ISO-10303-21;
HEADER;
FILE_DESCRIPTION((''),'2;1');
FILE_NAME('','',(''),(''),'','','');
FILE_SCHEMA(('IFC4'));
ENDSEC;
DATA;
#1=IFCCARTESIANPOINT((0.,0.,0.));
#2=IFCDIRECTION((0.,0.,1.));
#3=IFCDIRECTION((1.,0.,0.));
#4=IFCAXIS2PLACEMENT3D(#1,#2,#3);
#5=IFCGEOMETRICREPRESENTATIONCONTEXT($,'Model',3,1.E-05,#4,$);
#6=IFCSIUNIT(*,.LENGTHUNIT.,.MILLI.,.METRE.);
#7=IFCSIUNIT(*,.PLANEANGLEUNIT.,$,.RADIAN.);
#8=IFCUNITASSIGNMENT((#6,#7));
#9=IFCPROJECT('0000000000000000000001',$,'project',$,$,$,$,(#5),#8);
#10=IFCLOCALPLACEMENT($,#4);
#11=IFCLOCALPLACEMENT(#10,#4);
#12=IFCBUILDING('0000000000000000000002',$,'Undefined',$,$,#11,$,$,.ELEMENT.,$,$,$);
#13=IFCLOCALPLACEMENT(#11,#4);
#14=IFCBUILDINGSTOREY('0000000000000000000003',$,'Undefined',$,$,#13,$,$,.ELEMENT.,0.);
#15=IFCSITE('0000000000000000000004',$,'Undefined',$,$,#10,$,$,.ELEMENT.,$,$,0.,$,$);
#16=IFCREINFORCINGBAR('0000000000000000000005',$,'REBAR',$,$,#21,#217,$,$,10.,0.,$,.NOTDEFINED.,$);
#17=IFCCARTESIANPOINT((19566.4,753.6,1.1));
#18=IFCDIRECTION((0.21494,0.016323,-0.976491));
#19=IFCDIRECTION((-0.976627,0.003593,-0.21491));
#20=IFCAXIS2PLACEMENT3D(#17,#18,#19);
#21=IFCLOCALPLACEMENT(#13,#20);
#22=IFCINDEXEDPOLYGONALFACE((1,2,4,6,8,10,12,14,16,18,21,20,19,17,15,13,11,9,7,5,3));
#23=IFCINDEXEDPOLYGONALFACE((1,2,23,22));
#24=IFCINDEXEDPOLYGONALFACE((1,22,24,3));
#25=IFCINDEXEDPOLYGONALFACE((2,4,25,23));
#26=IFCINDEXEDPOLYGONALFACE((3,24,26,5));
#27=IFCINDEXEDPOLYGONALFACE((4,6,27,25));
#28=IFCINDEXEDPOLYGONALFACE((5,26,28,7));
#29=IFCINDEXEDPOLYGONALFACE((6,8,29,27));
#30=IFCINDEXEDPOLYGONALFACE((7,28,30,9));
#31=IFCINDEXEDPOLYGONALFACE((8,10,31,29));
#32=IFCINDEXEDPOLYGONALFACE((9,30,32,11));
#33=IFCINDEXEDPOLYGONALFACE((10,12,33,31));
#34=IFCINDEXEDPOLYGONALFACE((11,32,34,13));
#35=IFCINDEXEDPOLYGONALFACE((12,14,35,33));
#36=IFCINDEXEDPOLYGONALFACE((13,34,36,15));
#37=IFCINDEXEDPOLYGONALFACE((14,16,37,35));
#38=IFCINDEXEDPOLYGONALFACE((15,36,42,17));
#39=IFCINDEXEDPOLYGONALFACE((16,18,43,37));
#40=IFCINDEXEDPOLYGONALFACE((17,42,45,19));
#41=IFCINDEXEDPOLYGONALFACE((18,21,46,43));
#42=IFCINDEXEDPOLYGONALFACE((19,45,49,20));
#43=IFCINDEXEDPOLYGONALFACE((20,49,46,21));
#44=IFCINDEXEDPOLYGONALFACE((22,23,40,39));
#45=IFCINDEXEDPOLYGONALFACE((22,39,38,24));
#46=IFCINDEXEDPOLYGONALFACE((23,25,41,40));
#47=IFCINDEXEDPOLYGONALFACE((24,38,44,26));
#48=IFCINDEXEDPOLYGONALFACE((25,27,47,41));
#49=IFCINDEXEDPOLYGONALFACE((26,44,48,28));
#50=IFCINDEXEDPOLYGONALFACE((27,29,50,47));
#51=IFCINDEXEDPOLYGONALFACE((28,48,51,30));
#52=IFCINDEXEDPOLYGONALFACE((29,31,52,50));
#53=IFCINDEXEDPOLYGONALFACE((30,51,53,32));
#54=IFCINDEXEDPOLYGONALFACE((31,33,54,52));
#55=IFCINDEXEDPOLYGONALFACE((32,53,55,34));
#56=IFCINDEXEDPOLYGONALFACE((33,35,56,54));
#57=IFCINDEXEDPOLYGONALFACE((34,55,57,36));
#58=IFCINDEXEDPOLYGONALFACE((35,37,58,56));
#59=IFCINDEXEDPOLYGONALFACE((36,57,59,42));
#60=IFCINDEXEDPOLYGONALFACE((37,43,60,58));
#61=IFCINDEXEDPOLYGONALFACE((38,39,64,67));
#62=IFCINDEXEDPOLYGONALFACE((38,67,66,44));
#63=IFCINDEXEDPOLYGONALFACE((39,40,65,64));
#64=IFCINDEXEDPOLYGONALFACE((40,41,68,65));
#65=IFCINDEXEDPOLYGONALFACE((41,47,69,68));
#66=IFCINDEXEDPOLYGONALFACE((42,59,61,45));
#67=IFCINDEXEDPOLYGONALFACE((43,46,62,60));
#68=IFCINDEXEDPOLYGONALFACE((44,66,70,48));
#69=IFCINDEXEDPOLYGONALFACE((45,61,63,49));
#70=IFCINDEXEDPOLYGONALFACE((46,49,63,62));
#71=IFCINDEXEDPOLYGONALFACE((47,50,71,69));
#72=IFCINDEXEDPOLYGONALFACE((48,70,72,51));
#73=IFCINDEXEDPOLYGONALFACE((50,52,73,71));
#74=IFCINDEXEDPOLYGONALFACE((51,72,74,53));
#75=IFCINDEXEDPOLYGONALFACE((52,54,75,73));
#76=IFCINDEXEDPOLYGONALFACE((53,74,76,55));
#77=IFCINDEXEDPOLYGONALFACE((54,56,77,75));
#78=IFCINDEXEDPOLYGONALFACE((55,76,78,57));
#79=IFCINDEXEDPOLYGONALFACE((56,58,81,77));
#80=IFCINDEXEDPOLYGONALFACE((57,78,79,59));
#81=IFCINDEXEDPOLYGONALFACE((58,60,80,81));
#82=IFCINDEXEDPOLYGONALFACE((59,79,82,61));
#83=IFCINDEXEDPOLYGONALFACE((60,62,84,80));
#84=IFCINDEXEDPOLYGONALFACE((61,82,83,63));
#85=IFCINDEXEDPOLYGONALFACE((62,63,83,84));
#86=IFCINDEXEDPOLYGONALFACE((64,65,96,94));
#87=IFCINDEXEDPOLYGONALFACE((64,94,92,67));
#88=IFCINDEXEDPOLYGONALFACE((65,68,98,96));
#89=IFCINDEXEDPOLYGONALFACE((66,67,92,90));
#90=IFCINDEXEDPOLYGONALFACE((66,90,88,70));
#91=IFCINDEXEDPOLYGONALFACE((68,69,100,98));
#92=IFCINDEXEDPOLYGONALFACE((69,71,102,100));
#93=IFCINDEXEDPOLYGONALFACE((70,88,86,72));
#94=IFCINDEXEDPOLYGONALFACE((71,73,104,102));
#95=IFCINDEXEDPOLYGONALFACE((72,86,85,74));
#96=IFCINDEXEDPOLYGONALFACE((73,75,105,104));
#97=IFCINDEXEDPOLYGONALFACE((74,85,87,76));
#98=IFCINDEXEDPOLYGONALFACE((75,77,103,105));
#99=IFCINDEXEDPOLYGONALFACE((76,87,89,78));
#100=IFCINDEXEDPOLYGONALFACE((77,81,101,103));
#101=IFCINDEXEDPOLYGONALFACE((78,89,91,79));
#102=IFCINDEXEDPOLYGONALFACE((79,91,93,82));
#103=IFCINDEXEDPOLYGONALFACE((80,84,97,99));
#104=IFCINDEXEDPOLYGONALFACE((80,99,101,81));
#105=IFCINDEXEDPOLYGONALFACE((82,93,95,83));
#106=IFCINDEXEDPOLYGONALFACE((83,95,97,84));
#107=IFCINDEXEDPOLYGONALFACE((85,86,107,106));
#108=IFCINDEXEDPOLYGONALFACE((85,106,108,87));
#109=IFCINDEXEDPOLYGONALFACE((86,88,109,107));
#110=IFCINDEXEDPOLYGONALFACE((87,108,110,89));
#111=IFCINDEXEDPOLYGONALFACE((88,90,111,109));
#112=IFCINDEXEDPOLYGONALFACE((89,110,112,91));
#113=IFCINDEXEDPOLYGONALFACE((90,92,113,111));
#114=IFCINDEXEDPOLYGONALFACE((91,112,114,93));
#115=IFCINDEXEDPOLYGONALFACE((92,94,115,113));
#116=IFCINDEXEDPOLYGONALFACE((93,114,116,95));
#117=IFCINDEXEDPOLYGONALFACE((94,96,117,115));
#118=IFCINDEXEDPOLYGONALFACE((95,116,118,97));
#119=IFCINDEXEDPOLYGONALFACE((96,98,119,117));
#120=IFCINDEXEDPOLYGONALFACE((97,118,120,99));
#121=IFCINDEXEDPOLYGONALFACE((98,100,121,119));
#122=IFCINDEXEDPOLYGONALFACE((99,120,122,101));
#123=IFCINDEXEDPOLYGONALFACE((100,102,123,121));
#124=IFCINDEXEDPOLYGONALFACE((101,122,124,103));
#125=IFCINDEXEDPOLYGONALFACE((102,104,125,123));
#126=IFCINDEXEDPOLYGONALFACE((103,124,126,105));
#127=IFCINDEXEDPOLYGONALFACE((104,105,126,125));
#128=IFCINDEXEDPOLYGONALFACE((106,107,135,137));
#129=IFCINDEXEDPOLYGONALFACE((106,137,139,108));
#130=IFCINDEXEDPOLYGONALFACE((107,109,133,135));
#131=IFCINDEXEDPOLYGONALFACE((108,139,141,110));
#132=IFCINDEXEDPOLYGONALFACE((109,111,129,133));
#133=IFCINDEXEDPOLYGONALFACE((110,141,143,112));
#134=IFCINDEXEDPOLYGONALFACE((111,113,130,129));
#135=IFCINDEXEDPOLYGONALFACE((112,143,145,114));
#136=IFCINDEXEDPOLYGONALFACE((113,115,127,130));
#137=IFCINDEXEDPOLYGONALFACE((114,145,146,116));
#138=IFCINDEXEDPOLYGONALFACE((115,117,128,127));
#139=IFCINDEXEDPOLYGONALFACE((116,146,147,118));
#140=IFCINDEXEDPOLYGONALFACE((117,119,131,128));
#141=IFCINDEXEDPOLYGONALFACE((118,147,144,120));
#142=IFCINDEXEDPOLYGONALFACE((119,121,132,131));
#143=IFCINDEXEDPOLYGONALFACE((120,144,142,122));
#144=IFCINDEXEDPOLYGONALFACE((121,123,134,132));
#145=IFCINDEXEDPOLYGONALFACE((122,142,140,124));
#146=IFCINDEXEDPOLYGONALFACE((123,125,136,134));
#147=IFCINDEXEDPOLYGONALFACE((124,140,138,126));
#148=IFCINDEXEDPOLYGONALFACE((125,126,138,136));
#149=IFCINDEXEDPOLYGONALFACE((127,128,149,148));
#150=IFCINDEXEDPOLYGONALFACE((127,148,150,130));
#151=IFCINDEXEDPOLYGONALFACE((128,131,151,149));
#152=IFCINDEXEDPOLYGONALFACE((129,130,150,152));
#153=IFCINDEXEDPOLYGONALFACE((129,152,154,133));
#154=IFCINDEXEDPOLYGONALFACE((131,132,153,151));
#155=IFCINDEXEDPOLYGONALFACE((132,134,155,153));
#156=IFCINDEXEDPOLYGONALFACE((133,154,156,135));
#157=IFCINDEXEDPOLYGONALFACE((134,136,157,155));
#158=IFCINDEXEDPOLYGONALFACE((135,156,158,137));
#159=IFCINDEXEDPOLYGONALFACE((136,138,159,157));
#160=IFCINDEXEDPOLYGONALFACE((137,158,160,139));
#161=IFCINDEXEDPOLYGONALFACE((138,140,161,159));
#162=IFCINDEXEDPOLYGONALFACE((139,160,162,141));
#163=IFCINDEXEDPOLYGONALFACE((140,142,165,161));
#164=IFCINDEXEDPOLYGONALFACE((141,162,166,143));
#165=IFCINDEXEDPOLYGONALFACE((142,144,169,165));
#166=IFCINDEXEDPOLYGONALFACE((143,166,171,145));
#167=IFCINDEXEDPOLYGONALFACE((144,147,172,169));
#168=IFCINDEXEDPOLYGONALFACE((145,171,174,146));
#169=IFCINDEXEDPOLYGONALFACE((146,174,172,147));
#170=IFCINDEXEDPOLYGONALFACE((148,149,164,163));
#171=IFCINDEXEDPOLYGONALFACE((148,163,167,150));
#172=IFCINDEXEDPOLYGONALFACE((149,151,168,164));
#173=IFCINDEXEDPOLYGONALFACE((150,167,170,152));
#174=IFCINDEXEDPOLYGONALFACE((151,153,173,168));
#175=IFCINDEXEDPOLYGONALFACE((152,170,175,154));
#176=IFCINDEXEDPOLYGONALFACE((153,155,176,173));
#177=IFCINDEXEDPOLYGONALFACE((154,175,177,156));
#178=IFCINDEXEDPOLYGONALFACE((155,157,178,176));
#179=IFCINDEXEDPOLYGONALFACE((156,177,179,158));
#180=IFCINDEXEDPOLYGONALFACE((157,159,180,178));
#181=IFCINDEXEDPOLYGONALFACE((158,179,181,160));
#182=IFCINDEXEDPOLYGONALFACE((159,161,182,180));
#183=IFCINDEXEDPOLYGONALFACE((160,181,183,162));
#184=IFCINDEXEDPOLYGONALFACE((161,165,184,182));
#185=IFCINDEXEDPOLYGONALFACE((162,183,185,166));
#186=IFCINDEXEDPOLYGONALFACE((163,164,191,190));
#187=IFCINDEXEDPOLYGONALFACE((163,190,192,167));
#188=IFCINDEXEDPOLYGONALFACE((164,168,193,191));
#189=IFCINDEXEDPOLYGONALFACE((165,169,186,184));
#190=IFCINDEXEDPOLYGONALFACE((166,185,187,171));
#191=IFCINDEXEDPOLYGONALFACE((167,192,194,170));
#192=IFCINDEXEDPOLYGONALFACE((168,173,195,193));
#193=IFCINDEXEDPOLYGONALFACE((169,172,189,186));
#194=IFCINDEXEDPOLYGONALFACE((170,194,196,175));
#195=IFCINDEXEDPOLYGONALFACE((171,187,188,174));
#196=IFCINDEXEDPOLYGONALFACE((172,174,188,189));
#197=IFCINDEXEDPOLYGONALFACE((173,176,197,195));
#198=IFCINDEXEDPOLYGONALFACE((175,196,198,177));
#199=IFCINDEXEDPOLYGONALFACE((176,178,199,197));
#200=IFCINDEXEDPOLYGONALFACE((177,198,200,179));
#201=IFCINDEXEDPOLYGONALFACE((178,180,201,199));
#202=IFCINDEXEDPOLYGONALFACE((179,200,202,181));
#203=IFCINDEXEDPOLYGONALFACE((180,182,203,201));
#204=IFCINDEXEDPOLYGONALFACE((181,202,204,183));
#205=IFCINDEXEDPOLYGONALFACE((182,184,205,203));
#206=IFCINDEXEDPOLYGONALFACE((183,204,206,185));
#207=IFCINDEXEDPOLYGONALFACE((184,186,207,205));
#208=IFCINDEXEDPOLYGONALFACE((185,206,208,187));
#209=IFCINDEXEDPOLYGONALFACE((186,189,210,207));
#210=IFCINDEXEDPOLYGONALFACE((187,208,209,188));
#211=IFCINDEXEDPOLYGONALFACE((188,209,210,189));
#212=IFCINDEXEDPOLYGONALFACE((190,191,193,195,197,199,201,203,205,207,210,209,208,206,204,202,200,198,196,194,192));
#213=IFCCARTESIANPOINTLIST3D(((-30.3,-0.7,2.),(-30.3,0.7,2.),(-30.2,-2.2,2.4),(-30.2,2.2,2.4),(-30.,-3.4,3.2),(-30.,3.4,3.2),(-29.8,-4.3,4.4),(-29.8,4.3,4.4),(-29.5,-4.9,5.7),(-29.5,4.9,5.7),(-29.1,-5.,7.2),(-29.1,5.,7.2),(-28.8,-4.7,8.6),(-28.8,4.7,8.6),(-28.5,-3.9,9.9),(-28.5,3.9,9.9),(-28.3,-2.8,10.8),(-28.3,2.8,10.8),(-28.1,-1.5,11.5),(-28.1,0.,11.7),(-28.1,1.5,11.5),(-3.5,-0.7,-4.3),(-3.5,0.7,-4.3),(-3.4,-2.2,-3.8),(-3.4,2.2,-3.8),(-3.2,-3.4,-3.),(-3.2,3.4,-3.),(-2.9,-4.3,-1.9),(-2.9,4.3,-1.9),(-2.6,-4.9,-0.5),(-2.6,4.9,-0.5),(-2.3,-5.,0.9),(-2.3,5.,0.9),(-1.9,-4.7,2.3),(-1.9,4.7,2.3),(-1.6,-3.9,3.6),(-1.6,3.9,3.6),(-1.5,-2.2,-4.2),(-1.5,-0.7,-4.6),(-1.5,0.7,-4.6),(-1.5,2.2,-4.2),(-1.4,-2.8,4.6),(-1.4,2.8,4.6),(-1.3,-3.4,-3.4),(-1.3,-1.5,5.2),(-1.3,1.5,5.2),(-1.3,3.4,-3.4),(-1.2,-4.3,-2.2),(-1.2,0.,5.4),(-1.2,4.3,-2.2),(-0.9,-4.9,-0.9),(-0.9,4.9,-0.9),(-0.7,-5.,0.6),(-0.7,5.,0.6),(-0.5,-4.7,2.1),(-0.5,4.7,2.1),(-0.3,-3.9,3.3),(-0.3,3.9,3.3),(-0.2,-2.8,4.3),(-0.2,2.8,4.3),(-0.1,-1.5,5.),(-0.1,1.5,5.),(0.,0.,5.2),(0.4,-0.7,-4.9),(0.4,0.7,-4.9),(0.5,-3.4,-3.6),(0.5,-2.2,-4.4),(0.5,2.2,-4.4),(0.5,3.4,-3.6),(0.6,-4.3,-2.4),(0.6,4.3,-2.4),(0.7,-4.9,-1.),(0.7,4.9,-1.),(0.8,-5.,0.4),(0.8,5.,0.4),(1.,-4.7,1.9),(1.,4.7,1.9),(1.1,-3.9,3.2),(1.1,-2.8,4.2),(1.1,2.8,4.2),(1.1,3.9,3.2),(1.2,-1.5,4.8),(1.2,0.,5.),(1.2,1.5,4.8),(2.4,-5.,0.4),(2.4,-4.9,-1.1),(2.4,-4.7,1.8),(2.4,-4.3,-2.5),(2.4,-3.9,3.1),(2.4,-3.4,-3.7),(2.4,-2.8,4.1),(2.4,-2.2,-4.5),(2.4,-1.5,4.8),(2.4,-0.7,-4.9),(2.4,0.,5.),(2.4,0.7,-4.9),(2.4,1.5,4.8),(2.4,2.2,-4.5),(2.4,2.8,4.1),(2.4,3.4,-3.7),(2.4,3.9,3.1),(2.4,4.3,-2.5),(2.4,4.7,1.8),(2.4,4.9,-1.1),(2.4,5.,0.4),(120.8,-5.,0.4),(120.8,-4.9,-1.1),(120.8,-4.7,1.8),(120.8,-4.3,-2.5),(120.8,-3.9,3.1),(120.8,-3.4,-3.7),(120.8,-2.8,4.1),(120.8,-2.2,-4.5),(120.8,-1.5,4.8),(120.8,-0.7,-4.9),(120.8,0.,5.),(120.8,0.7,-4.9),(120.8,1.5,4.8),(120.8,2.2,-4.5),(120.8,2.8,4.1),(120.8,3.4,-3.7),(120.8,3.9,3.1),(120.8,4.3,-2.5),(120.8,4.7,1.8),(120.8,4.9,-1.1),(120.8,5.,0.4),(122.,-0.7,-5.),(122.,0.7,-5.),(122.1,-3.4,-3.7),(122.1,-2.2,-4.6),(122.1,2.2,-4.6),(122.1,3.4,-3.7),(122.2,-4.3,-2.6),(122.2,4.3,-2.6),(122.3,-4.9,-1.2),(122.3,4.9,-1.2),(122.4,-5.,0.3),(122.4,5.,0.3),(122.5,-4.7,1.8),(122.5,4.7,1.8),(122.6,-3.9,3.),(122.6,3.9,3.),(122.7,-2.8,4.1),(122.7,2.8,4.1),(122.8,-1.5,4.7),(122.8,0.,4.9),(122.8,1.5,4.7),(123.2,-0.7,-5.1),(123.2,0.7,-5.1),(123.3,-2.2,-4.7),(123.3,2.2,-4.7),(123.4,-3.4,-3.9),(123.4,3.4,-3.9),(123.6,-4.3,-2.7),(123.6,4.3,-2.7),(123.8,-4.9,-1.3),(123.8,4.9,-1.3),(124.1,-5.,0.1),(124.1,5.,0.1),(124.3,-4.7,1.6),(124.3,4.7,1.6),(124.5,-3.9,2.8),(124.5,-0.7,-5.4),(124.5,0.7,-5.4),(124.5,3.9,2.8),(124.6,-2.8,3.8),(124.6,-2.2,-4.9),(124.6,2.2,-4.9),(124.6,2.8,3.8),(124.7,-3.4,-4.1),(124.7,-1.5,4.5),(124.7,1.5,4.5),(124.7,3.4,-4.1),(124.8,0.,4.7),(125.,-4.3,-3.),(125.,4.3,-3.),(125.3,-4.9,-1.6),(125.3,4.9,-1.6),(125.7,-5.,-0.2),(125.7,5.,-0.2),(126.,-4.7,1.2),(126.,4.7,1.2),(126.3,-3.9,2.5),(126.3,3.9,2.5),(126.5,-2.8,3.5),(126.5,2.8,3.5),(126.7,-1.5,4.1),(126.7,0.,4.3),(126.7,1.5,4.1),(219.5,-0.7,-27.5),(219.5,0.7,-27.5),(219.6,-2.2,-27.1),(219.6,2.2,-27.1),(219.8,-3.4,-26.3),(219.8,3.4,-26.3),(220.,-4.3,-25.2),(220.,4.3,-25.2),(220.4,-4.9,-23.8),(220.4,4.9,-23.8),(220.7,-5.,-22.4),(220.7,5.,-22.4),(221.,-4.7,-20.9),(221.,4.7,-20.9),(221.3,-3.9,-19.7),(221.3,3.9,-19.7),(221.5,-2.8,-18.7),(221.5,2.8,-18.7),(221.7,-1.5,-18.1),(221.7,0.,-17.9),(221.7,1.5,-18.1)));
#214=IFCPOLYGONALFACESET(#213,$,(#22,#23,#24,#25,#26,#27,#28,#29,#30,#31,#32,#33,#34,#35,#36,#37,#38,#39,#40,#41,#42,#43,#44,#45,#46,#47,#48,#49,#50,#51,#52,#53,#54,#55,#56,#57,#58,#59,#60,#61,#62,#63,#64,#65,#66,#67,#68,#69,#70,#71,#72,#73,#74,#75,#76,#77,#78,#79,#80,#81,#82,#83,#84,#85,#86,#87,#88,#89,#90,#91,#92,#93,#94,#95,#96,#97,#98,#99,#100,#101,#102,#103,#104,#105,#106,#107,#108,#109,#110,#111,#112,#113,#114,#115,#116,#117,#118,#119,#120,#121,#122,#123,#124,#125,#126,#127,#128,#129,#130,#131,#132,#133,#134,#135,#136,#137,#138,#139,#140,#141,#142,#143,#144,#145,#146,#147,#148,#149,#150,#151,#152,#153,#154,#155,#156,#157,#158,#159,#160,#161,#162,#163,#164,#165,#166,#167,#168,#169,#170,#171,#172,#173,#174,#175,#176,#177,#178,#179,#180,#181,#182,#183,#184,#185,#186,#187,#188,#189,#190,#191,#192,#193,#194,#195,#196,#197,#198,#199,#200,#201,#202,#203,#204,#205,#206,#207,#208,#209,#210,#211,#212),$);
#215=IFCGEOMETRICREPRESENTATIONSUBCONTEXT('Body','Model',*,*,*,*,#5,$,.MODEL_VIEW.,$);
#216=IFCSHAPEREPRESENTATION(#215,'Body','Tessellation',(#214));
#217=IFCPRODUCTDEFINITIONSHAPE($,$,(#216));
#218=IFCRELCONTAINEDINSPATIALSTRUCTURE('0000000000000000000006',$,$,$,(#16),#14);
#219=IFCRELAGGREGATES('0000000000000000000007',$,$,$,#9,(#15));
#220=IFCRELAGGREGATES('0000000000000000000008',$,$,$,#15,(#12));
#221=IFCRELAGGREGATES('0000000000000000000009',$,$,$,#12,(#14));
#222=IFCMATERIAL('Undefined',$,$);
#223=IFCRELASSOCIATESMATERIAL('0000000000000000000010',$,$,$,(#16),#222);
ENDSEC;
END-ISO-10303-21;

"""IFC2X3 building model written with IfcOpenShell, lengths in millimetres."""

from ifc_helpers import new_model, entity, si_unit, frame, origin_with_axes, place, context, subcontext, project, spatial, source, transform, mapped, material, element, save


model = new_model("IFC2X3")

# Units and contexts
model_context = context("Model", 3, precision=1e-05, world=origin_with_axes())
body_context = subcontext(model_context, "Body", "Model", "MODEL_VIEW")
ifc_project = project(units=[si_unit("LENGTHUNIT", "METRE", prefix="MILLI"), si_unit("PLANEANGLEUNIT", "RADIAN")], contexts=[model_context])

# Site, building, storey
site_placement = place(None, origin_with_axes())
site = spatial("IfcSite", under=ifc_project, at=site_placement, Name="Undefined", CompositionType="ELEMENT", RefElevation=0.0)
building_placement = place(site_placement, origin_with_axes())
building = spatial("IfcBuilding", under=site, at=building_placement, Name="Undefined", CompositionType="ELEMENT")
storey_placement = place(building_placement, origin_with_axes())
storey = spatial("IfcBuildingStorey", under=building, at=storey_placement, Name="Undefined", CompositionType="ELEMENT", Elevation=0.0)

# Reinforcing bar
ifc_material_1 = material(Name="Undefined")
ifc_direction_1 = entity("IfcDirection", [0.973841, 0.0, -0.22723])
shared_shape_1 = source(origin_with_axes(), body_context, "Body", "AdvancedSweptSolid", [
    entity("IfcSweptDiskSolid", entity("IfcCompositeCurve", [entity("IfcCompositeCurveSegment", "CONTINUOUS", True, entity("IfcTrimmedCurve", entity("IfcLine", entity("IfcCartesianPoint", [0.0, 0.0, 0.0]), entity("IfcVector", ifc_direction_1, 1.0)), [entity("IfcParameterValue", 0.0)], [entity("IfcParameterValue", 27.582469)], True, "PARAMETER")), entity("IfcCompositeCurveSegment", "CONTINUOUS", True, entity("IfcTrimmedCurve", entity("IfcCircle", entity("IfcAxis2Placement3D", entity("IfcCartesianPoint", [31.6, 0.0, 14.2]), entity("IfcDirection", [0.0, -1.0, 0.0]), entity("IfcDirection", [-0.22723, 0.0, -0.973841])), 21.0), [entity("IfcParameterValue", 0.0)], [entity("IfcParameterValue", 0.229232)], True, "PARAMETER")), entity("IfcCompositeCurveSegment", "CONTINUOUS", True, entity("IfcTrimmedCurve", entity("IfcLine", entity("IfcCartesianPoint", [31.6, 0.0, -6.8]), entity("IfcVector", entity("IfcDirection", [1.0, 0.0, 0.0]), 1.0)), [entity("IfcParameterValue", 0.0)], [entity("IfcParameterValue", 118.388313)], True, "PARAMETER")), entity("IfcCompositeCurveSegment", "CONTINUOUS", True, entity("IfcTrimmedCurve", entity("IfcCircle", entity("IfcAxis2Placement3D", entity("IfcCartesianPoint", [150.0, 0.0, -27.8]), entity("IfcDirection", [0.0, 1.0, 0.0]), entity("IfcDirection", [0.0, 0.0, 1.0])), 21.0), [entity("IfcParameterValue", 0.0)], [entity("IfcParameterValue", 0.229232)], True, "PARAMETER")), entity("IfcCompositeCurveSegment", "DISCONTINUOUS", True, entity("IfcTrimmedCurve", entity("IfcLine", entity("IfcCartesianPoint", [154.8, 0.0, -7.4]), entity("IfcVector", ifc_direction_1, 1.0)), [entity("IfcParameterValue", 0.0)], [entity("IfcParameterValue", 97.582469)], True, "PARAMETER"))], False), 5.0, None, 0.0, 244.0),
])
reinforcing_bar_1_placement = place(storey_placement, frame((19566.4, 753.6, 1.1), z_axis=(0.21494, 0.016323, -0.976491), x_axis=(-0.976627, 0.003593, -0.21491)))
element("IfcReinforcingBar", 1, at=reinforcing_bar_1_placement, inside=storey, material=ifc_material_1, Name="REBAR", BarRole="NOTDEFINED", CrossSectionArea=0.0, NominalDiameter=10.0, context=body_context, shape_type="MappedRepresentation", body=[
    mapped(shared_shape_1, transform((-29.2, 0.0, 6.8))),
])

save(model, "model.ifc")
